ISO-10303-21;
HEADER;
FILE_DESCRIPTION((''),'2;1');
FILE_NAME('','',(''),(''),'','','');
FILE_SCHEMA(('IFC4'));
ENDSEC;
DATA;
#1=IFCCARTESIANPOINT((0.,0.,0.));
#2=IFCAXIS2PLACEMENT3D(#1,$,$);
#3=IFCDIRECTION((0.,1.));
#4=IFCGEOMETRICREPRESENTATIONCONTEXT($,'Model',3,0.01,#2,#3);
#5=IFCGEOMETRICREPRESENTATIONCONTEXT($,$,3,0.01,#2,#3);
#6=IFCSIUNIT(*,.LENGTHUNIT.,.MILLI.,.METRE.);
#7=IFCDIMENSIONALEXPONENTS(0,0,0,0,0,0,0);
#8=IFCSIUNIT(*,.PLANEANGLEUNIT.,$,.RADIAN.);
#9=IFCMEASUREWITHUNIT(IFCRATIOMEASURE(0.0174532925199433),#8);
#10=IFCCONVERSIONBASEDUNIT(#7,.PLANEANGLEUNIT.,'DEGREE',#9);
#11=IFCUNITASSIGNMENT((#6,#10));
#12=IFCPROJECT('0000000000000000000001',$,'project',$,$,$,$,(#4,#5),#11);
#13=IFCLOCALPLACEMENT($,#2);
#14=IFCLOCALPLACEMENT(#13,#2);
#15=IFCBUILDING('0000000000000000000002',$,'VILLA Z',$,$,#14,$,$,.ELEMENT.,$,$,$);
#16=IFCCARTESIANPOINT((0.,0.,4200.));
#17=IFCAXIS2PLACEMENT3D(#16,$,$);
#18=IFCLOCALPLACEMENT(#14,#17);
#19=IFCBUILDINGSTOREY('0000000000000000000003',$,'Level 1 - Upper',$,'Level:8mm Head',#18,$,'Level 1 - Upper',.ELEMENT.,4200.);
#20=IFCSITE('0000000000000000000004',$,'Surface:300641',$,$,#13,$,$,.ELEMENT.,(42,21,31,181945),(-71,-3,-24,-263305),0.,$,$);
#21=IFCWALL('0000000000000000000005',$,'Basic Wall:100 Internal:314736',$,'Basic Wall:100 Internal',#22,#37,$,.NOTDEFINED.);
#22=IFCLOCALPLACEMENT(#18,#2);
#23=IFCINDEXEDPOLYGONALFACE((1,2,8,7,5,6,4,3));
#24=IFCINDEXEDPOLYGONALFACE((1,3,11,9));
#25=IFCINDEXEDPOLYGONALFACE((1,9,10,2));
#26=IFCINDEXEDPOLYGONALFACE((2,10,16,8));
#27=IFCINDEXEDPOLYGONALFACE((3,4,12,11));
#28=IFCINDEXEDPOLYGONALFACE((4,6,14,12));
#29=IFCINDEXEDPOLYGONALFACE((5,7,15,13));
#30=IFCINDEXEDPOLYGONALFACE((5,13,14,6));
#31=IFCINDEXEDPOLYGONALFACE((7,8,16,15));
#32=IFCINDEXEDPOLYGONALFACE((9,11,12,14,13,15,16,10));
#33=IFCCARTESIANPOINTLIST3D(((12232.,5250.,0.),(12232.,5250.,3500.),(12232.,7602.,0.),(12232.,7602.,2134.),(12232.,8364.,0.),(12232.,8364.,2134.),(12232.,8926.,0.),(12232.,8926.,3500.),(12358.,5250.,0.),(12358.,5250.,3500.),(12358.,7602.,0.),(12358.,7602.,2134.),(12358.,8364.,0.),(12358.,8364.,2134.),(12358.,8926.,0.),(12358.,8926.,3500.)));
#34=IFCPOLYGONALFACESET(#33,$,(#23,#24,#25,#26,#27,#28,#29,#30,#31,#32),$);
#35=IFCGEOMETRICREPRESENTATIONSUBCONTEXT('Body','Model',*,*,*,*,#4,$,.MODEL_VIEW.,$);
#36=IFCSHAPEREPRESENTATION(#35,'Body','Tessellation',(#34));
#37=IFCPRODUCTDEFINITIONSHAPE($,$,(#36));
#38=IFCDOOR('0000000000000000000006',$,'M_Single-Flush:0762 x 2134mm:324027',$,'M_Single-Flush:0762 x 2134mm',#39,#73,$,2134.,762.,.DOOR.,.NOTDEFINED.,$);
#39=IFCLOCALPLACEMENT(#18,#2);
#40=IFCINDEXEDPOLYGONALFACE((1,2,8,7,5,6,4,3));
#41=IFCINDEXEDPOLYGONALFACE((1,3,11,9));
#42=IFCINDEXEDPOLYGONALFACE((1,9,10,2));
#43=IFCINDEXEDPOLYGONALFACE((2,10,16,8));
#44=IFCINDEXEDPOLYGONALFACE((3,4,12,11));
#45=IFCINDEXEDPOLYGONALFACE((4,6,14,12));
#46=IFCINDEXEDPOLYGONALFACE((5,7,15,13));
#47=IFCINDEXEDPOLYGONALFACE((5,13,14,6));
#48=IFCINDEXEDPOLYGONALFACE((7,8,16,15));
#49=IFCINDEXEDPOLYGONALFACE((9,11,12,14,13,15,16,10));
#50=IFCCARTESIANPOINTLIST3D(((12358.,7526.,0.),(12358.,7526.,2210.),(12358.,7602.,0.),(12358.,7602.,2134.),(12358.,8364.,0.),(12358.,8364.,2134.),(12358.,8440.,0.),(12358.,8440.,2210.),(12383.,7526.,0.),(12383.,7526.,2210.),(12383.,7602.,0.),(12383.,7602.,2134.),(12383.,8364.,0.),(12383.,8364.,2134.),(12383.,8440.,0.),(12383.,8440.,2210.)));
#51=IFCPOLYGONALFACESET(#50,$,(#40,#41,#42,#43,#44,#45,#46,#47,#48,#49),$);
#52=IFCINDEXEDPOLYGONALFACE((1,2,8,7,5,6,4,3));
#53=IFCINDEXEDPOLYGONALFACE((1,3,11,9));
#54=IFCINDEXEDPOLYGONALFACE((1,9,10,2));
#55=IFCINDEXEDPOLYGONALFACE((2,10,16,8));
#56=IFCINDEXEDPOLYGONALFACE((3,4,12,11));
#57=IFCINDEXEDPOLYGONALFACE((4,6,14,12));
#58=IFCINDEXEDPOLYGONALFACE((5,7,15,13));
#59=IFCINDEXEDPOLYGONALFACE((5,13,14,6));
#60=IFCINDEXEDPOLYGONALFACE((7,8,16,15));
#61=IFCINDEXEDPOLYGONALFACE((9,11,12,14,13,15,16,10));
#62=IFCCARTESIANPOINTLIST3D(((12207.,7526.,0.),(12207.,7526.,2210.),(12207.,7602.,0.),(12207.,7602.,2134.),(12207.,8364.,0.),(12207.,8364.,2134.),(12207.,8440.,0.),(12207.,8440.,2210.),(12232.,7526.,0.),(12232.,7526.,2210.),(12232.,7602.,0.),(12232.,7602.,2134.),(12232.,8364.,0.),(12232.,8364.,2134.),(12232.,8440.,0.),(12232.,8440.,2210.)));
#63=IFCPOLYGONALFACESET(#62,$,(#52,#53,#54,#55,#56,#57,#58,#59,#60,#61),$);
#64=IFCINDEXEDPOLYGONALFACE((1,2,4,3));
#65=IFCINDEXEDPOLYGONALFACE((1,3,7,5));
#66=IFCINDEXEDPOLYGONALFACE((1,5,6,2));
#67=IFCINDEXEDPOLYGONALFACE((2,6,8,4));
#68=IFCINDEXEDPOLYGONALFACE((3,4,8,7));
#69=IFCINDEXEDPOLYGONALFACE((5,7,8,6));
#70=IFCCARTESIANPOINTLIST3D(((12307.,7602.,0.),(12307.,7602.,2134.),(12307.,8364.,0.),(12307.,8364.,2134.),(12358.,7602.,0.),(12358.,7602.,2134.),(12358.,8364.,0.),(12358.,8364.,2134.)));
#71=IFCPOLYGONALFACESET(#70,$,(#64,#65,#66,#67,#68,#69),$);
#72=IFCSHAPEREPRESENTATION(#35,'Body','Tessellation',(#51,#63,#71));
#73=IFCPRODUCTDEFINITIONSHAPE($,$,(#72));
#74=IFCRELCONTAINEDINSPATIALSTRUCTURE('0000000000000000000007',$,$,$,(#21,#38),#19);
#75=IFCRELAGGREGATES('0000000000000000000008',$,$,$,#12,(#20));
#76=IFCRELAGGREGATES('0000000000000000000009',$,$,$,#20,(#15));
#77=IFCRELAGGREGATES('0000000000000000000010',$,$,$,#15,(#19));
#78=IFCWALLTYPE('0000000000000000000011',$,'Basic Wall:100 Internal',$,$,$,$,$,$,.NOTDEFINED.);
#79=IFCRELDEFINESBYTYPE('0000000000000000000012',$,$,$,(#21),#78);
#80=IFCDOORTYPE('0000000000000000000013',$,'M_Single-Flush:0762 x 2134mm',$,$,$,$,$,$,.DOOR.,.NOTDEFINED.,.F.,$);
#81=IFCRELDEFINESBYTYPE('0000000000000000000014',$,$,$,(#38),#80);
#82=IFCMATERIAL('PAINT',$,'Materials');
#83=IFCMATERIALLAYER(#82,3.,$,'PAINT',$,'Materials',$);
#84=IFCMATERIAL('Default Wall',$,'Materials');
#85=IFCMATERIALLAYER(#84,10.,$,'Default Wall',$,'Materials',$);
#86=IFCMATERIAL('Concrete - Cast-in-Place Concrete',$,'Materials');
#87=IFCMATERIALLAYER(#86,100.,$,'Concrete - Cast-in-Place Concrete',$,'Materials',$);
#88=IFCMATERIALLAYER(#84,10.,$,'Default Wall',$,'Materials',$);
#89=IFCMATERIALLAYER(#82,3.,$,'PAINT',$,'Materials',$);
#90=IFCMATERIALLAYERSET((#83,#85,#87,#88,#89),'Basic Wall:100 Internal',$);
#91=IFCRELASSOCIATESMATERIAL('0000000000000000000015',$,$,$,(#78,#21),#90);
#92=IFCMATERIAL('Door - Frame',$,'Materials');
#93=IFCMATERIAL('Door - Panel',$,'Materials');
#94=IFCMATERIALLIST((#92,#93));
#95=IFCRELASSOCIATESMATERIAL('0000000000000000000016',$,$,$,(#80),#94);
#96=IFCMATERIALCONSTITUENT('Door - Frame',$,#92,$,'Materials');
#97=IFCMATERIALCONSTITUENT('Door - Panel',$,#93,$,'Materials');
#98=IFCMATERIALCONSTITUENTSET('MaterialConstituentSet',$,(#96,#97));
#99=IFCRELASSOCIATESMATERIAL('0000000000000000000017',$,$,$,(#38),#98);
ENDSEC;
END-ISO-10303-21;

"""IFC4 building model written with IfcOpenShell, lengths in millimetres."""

from ifc_helpers import new_model, entity, si_unit, converted_unit, direction, frame, frame_2d, origin, place, context, subcontext, project, spatial, polyline, rectangle, outline, extrude, clip, halfspace, source, transform, mapped, material, material_list, layer, layer_set, layer_usage, constituent, constituent_set, type_object, type_shapes, element, fill, save


model = new_model("IFC4")

# Units and contexts
model_context = context("Model", 3, precision=0.01, world=origin(), true_north=direction((0.0, 1.0)))
context_of_model = context(None, 3, precision=0.01, world=origin(), true_north=direction((0.0, 1.0)))
body_context = subcontext(model_context, "Body", "Model", "MODEL_VIEW")
ifc_project = project(units=[si_unit("LENGTHUNIT", "METRE", prefix="MILLI"), converted_unit("PLANEANGLEUNIT", "DEGREE", entity("IfcRatioMeasure", 0.0174532925199433), si_unit("PLANEANGLEUNIT", "RADIAN"), dimensions=[0, 0, 0, 0, 0, 0, 0])], contexts=[model_context, context_of_model])

# Site, building, storey
site_placement = place(None, origin())
site = spatial("IfcSite", under=ifc_project, at=site_placement, Name="Surface:300641", CompositionType="ELEMENT", RefLatitude=(42, 21, 31, 181945), RefLongitude=(-71, -3, -24, -263305), RefElevation=0.0)
building_placement = place(site_placement, origin())
building = spatial("IfcBuilding", under=site, at=building_placement, Name="VILLA Z", CompositionType="ELEMENT")
storey_placement = place(building_placement, frame((0.0, 0.0, 4200.0)))
storey = spatial("IfcBuildingStorey", under=building, at=storey_placement, Name="Level 1 - Upper", ObjectType="Level:8mm Head", LongName="Level 1 - Upper", CompositionType="ELEMENT", Elevation=4200.0)

# Shared definitions
ifc_material_1 = material(Name="Concrete - Cast-in-Place Concrete", Category="Materials")

# Shared definitions
ifc_material_2 = material(Name="PAINT", Category="Materials")
ifc_material_3 = material(Name="Default Wall", Category="Materials")

# Wall, opening, door
ifc_layer_1 = layer(ifc_material_2, 3.0, Name="PAINT", Category="Materials")
ifc_layer_2 = layer(ifc_material_3, 10.0, Name="Default Wall", Category="Materials")
ifc_layer_3 = layer(ifc_material_1, 100.0, Name="Concrete - Cast-in-Place Concrete", Category="Materials")
ifc_layer_4 = layer(ifc_material_3, 10.0, Name="Default Wall", Category="Materials")
ifc_layer_5 = layer(ifc_material_2, 3.0, Name="PAINT", Category="Materials")
ifc_layer_set_1 = layer_set([ifc_layer_1, ifc_layer_2, ifc_layer_3, ifc_layer_4, ifc_layer_5], Name="Basic Wall:100 Internal")
ifc_layer_usage_1 = layer_usage(ifc_layer_set_1, "AXIS2", "NEGATIVE", 63.0)
wall_type_1 = type_object("IfcWallType", Name="Basic Wall:100 Internal", PredefinedType="NOTDEFINED", material=ifc_layer_set_1)
wall_1_placement = place(storey_placement, frame((12295.0, 5250.0, 0.0), z_axis=(0.0, 0.0, 1.0), x_axis=(0.0, 1.0, 0.0)))
wall_1 = element("IfcWall", 1, at=wall_1_placement, inside=storey, type_object=wall_type_1, material=ifc_layer_usage_1, Name="Basic Wall:100 Internal:314736", ObjectType="Basic Wall:100 Internal", PredefinedType="NOTDEFINED", context=body_context, shape_type="Clipping", body=[
    clip(extrude(rectangle(XDim=3676.0, YDim=126.0, at=frame_2d((1838.0, 0.0), x_axis=(-1.0, 0.0))), origin(), (0.0, 0.0, 1.0), 3500.0), halfspace(origin(), True)),
])
opening_1_placement = place(wall_1_placement, frame((3114.0, 63.0, 0.0)))
opening_1 = element("IfcOpeningElement", 2, at=opening_1_placement, cuts=wall_1, ObjectType="Opening", PredefinedType="OPENING", context=body_context, shape_type="SweptSolid", body=[
    extrude(rectangle(XDim=762.0, YDim=2134.0, at=frame_2d((1067.0, 381.0), x_axis=(0.0, -1.0))), frame((0.0, 0.0, 0.0), z_axis=(0.0, -1.0, 0.0), x_axis=(0.0, 0.0, 1.0)), (0.0, 0.0, 1.0), 126.0),
])
ifc_material_4 = material(Name="Door - Frame", Category="Materials")
ifc_constituent_1 = constituent(ifc_material_4, Name="Door - Frame", Category="Materials")
ifc_material_5 = material(Name="Door - Panel", Category="Materials")
ifc_constituent_2 = constituent(ifc_material_5, Name="Door - Panel", Category="Materials")
ifc_constituent_set = constituent_set(constituents=[ifc_constituent_1, ifc_constituent_2], Name="MaterialConstituentSet")
ifc_material_list = material_list([ifc_material_4, ifc_material_5])
door_type = type_object("IfcDoorType", Name="M_Single-Flush:0762 x 2134mm", OperationType="NOTDEFINED", ParameterTakesPrecedence=False, PredefinedType="DOOR", material=ifc_material_list)
shared_shape_1 = source(origin(), body_context, "Body", "SweptSolid", [
    extrude(outline(polyline([(-457.0, -1124.0), (457.0, -1124.0), (457.0, 1086.0), (381.0, 1086.0), (381.0, -1048.0), (-381.0, -1048.0), (-381.0, 1086.0), (-457.0, 1086.0), (-457.0, -1124.0)])), frame((381.0, 151.0, 1086.0), z_axis=(0.0, -1.0, 0.0), x_axis=(-1.0, 0.0, 0.0)), (0.0, 0.0, 1.0), 25.0),
    extrude(outline(polyline([(-1124.0, -457.0), (1086.0, -457.0), (1086.0, -381.0), (-1048.0, -381.0), (-1048.0, 381.0), (1086.0, 381.0), (1086.0, 457.0), (-1124.0, 457.0), (-1124.0, -457.0)])), frame((381.0, 0.0, 1086.0), z_axis=(0.0, -1.0, 0.0), x_axis=(0.0, 0.0, -1.0)), (0.0, 0.0, 1.0), 25.0),
    extrude(rectangle(XDim=762.0, YDim=51.0, at=frame_2d((0.0, 0.0), x_axis=(1.0, 0.0))), frame((381.0, 100.5, 0.0)), (0.0, 0.0, 1.0), 2134.0),
])
type_shapes(door_type, [shared_shape_1])
door_placement = place(opening_1_placement, frame((0.0, 0.0, 0.0), z_axis=(0.0, 0.0, 1.0), x_axis=(-1.0, 0.0, 0.0)))
door = element("IfcDoor", 3, at=door_placement, inside=storey, type_object=door_type, material=ifc_constituent_set, Name="M_Single-Flush:0762 x 2134mm:324027", ObjectType="M_Single-Flush:0762 x 2134mm", OperationType="NOTDEFINED", OverallHeight=2134.0, OverallWidth=762.0, PredefinedType="DOOR", context=body_context, shape_type="MappedRepresentation", body=[
    mapped(shared_shape_1, transform((0.0, 0.0, 0.0), scale=1.0)),
])
fill(opening_1, door)

save(model, "model.ifc")
